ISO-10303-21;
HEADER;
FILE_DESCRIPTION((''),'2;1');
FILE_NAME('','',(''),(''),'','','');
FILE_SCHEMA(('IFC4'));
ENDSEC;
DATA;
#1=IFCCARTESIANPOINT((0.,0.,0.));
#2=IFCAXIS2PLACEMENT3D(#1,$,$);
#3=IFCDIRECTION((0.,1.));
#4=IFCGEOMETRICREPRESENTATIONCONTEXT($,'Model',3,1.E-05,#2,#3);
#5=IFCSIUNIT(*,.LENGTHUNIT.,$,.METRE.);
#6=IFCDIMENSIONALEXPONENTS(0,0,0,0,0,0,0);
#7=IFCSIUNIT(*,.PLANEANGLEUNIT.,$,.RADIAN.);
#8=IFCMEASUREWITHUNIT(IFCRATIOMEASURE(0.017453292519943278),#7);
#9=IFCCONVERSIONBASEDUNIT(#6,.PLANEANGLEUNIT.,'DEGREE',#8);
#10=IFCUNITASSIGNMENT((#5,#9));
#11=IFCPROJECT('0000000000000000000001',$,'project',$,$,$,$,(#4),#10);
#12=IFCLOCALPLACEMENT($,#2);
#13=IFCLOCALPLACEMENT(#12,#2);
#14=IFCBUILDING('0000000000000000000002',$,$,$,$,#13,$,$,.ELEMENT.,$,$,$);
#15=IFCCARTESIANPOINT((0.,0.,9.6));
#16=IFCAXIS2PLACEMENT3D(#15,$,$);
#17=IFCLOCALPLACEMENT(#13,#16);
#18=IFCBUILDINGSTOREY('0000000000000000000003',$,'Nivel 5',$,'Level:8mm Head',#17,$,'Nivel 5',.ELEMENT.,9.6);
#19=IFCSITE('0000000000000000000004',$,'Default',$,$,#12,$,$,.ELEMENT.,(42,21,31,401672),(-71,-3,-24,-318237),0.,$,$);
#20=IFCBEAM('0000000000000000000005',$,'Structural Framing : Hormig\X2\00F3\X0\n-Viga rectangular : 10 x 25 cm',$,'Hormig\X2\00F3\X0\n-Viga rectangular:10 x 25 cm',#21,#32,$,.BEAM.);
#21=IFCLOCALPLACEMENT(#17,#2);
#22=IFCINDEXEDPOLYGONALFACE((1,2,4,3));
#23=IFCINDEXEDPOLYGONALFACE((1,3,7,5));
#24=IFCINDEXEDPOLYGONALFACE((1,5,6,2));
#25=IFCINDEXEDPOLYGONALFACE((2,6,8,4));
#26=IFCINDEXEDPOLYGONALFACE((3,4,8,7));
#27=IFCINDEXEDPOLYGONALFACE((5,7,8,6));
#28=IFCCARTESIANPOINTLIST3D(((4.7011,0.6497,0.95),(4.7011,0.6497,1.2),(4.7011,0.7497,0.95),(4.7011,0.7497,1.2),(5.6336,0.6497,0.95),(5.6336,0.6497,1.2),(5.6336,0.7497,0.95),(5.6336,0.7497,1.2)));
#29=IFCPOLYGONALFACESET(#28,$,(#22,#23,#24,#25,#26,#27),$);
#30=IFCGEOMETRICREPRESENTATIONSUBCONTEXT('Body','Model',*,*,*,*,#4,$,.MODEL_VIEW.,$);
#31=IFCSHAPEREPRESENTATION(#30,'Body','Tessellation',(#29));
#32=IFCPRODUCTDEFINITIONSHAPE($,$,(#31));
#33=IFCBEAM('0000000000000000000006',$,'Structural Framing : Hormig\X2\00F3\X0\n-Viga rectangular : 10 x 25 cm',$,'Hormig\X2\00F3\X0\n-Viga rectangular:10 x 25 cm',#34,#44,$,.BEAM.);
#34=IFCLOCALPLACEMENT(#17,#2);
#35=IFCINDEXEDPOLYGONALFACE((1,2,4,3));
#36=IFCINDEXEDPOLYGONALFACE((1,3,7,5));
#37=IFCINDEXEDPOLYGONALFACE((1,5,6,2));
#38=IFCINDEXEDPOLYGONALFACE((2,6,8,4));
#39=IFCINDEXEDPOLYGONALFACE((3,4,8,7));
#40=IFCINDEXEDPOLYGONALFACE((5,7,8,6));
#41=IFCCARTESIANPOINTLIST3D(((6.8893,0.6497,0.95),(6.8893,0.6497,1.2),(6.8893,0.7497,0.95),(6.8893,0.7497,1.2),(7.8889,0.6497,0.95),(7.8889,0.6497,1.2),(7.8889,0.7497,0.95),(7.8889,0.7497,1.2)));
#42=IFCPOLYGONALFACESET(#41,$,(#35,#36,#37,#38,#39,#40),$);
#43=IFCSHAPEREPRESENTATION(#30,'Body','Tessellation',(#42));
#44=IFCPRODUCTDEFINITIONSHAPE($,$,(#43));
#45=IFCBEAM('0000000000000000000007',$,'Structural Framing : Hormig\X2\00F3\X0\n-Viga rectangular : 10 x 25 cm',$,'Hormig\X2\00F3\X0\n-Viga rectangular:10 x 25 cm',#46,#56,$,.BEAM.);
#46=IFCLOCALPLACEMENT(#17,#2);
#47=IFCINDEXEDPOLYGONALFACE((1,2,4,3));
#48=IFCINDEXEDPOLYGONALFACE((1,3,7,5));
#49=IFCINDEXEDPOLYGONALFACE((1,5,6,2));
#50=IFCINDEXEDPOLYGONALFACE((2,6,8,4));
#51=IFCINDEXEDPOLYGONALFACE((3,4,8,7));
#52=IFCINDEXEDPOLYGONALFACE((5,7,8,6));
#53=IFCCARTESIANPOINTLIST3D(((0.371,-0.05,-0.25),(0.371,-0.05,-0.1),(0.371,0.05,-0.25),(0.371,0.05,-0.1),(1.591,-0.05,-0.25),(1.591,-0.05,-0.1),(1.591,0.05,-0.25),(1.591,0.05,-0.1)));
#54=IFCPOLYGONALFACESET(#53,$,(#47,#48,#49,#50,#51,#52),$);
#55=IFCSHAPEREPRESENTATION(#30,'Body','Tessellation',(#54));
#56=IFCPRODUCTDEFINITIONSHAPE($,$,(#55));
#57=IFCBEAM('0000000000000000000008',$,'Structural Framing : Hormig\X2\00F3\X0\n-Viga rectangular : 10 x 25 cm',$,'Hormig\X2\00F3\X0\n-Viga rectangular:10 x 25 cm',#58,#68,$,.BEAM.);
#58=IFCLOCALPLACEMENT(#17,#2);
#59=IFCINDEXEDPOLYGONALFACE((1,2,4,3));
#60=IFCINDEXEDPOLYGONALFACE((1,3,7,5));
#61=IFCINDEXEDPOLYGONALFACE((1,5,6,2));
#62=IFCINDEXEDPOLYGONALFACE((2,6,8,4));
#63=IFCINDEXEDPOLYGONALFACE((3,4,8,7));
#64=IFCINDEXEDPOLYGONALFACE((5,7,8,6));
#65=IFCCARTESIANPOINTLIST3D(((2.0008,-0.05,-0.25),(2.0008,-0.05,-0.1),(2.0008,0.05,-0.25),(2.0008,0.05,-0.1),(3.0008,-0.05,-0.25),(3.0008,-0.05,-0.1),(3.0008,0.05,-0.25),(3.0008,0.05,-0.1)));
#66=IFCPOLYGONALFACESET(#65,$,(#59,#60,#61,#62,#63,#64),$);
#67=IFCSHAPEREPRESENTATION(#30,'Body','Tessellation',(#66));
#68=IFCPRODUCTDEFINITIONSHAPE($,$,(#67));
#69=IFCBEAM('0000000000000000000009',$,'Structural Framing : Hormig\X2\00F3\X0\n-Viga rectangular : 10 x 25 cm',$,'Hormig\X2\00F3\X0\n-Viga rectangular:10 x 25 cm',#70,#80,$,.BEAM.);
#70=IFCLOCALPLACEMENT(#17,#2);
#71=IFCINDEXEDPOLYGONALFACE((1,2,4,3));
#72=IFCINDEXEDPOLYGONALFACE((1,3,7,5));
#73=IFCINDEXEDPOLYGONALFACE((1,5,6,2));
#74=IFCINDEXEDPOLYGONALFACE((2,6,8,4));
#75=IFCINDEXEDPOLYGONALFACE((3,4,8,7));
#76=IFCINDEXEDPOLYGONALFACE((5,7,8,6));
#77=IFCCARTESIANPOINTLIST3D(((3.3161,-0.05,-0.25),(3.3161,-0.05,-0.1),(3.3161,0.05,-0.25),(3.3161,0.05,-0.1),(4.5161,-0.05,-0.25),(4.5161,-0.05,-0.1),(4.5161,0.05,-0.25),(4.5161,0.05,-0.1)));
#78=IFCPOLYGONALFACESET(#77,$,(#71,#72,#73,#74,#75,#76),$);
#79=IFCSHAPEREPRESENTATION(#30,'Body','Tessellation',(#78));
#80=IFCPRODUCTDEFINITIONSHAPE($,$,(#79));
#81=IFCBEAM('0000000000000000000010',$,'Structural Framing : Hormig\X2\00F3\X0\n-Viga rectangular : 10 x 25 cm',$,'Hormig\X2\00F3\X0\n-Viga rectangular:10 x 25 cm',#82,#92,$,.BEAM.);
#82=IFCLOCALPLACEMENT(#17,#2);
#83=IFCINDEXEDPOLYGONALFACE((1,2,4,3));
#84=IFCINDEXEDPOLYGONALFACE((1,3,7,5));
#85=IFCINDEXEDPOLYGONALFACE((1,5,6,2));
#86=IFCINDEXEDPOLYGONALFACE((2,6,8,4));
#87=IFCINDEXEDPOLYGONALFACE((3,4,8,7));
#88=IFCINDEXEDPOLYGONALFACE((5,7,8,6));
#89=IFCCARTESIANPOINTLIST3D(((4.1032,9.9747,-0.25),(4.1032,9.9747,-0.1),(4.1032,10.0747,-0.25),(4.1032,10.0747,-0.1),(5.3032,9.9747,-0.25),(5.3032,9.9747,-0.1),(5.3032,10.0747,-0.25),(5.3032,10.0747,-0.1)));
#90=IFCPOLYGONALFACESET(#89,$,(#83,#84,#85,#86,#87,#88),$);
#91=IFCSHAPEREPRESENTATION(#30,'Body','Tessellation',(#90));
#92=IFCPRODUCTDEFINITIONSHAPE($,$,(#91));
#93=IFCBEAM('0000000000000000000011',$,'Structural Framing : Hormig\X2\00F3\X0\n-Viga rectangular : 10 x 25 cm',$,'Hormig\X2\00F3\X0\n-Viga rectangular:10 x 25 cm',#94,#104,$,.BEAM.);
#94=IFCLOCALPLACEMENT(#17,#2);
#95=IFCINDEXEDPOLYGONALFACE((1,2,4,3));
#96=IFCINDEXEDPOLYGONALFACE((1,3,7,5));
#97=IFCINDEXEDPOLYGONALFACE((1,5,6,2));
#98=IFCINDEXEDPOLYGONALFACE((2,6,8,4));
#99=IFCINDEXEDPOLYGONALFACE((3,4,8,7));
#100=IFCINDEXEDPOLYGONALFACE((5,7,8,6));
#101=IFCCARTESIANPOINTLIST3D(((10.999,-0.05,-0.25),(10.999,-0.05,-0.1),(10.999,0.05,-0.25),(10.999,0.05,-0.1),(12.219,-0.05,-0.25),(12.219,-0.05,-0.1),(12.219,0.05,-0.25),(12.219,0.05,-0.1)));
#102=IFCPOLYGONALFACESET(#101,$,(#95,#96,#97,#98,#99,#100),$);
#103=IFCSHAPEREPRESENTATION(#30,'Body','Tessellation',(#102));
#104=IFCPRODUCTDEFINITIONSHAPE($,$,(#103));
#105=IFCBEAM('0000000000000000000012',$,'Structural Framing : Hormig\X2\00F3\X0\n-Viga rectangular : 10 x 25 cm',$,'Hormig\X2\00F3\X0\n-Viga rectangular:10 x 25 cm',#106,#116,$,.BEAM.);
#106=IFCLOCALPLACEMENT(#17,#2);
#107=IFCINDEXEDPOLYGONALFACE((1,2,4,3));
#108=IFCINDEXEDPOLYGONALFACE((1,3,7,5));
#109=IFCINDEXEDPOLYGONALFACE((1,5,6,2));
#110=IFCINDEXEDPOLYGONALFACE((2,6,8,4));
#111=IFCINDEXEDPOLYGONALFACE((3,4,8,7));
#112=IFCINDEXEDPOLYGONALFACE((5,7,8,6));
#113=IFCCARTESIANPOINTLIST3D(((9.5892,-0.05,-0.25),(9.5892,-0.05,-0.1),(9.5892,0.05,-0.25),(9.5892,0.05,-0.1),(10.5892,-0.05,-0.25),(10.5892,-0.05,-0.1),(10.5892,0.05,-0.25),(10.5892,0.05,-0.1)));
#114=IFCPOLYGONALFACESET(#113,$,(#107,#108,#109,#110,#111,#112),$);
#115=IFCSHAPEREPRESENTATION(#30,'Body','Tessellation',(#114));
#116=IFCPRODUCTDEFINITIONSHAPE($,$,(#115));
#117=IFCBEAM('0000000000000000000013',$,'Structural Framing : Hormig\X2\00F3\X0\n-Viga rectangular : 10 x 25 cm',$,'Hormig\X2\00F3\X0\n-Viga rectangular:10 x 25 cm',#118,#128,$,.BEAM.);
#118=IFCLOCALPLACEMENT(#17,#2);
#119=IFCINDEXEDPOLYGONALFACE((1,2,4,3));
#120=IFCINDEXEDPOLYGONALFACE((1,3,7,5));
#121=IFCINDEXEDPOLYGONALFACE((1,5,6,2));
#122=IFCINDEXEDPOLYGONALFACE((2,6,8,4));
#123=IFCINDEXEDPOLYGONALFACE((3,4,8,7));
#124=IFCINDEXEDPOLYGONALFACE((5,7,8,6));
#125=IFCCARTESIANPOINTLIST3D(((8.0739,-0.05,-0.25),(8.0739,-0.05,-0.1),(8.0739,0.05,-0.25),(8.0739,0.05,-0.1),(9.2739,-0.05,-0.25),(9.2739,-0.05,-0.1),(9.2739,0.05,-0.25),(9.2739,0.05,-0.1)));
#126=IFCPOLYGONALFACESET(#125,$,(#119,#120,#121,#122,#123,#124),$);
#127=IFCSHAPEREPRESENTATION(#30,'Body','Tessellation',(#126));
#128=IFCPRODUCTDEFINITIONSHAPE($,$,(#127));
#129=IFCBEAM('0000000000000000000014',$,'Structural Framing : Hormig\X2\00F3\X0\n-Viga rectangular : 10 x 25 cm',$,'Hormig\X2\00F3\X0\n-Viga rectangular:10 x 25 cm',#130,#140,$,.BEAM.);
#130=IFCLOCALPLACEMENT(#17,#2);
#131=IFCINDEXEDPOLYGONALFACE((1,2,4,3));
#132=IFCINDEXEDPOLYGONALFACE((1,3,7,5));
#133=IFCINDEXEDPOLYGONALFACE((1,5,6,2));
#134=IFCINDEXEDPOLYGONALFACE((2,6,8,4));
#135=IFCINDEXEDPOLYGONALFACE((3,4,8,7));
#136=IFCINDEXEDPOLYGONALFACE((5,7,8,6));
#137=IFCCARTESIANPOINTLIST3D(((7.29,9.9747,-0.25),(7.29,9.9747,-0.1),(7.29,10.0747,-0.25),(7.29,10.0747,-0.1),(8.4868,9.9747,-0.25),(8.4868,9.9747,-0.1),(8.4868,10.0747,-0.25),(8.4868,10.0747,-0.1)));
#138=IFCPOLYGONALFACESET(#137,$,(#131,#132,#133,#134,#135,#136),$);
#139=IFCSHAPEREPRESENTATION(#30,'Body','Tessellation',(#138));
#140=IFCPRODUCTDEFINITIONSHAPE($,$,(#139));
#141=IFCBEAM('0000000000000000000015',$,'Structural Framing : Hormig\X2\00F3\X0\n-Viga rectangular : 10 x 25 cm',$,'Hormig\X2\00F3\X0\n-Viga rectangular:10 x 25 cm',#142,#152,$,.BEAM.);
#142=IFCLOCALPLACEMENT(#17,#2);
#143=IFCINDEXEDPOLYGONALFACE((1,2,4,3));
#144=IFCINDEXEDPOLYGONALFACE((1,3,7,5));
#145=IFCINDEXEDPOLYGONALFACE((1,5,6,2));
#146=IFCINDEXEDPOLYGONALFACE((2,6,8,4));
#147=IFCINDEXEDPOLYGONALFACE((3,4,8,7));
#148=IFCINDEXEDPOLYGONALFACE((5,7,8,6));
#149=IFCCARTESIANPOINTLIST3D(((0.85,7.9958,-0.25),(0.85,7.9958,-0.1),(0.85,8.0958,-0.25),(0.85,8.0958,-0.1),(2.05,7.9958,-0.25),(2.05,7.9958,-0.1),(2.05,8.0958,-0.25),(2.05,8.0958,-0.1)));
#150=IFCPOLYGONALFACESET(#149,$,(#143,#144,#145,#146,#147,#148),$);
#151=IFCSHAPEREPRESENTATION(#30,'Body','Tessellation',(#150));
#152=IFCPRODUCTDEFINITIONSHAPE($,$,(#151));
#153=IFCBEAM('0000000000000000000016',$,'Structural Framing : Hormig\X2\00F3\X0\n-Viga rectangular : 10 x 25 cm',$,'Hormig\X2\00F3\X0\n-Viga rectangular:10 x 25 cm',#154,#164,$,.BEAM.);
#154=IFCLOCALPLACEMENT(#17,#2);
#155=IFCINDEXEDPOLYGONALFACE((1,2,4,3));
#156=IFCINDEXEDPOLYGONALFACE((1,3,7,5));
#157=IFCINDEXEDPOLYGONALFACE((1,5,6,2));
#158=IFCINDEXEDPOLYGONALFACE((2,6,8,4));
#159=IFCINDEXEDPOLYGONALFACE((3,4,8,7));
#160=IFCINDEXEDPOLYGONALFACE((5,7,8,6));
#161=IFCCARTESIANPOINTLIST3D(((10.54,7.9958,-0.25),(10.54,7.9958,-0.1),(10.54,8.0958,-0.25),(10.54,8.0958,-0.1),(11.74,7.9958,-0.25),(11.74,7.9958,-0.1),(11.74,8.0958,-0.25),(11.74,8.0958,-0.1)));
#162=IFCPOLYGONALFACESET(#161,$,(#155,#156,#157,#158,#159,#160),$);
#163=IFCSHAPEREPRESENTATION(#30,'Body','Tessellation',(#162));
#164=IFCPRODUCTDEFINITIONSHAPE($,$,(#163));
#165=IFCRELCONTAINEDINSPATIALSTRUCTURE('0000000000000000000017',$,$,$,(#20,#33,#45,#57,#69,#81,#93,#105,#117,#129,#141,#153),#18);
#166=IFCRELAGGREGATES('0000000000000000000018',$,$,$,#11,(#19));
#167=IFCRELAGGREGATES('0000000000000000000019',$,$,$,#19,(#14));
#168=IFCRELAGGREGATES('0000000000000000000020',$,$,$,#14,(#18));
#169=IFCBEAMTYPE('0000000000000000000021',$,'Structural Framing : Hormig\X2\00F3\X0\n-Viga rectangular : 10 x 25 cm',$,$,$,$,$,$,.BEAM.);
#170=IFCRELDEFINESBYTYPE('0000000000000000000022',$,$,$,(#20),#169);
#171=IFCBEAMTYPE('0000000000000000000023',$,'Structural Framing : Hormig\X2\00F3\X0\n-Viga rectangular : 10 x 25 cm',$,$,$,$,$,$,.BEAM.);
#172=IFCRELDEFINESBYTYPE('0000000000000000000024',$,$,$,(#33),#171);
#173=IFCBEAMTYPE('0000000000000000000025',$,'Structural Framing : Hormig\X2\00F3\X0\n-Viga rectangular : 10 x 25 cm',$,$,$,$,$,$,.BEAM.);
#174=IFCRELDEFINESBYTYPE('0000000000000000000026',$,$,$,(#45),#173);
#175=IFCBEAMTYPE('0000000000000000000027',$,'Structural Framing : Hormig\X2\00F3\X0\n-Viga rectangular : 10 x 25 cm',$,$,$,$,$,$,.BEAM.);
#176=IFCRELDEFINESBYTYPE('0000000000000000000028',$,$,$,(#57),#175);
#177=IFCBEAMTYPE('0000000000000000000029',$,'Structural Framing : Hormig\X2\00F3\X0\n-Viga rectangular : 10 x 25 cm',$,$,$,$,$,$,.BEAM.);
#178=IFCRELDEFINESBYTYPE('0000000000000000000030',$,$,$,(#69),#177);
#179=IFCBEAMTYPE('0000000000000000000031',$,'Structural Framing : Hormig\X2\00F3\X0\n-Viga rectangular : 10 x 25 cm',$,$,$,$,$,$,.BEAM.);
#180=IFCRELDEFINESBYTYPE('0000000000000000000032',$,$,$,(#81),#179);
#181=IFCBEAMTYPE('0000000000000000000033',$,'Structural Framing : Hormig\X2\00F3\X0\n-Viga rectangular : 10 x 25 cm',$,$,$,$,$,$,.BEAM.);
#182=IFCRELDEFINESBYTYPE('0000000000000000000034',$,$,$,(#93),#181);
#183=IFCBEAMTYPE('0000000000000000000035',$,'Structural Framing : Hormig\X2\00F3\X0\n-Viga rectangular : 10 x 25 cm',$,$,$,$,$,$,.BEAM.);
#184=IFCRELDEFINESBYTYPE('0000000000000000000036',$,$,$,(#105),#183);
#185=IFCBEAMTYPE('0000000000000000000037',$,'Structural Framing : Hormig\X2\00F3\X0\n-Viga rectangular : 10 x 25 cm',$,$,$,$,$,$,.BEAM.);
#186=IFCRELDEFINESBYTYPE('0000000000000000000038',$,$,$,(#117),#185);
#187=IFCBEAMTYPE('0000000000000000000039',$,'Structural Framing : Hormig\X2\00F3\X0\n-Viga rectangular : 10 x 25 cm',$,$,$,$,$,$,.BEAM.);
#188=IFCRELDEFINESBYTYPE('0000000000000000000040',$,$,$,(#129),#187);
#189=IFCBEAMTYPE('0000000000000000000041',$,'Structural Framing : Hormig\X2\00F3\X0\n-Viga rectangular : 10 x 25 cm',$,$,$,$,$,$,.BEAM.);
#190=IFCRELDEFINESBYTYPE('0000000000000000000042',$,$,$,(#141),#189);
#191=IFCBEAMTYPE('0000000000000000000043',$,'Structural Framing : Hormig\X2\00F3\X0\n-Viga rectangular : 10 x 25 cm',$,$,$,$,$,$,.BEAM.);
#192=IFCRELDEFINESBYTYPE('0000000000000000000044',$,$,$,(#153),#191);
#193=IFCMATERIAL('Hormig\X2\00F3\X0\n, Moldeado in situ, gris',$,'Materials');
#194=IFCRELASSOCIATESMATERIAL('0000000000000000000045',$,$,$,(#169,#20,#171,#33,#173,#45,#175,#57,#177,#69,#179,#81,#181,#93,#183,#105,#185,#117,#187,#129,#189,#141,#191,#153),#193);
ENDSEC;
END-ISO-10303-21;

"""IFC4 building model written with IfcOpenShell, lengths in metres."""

from ifc_helpers import new_model, entity, si_unit, converted_unit, direction, frame, origin, place, context, subcontext, project, spatial, indexed_curve, outline, extrude, source, transform, mapped, material, type_object, type_shapes, element, save


model = new_model("IFC4")

# Units and contexts
model_context = context("Model", 3, precision=1e-05, world=origin(), true_north=direction((0.0, 1.0)))
body_context = subcontext(model_context, "Body", "Model", "MODEL_VIEW")
ifc_project = project(units=[si_unit("LENGTHUNIT", "METRE"), converted_unit("PLANEANGLEUNIT", "DEGREE", entity("IfcRatioMeasure", 0.017453292519943278), si_unit("PLANEANGLEUNIT", "RADIAN"), dimensions=[0, 0, 0, 0, 0, 0, 0])], contexts=[model_context])

# Site, building, storey
site_placement = place(None, origin())
site = spatial("IfcSite", under=ifc_project, at=site_placement, Name="Default", CompositionType="ELEMENT", RefLatitude=(42, 21, 31, 401672), RefLongitude=(-71, -3, -24, -318237), RefElevation=0.0)
building_placement = place(site_placement, origin())
building = spatial("IfcBuilding", under=site, at=building_placement, CompositionType="ELEMENT")
storey_placement = place(building_placement, frame((0.0, 0.0, 9.6)))
storey = spatial("IfcBuildingStorey", under=building, at=storey_placement, Name="Nivel 5", ObjectType="Level:8mm Head", LongName="Nivel 5", CompositionType="ELEMENT", Elevation=9.6)

# Beams
ifc_material_1 = material(Name="Hormigón, Moldeado in situ, gris", Category="Materials")
beam_type_1 = type_object("IfcBeamType", Name="Structural Framing : Hormigón-Viga rectangular : 10 x 25 cm", PredefinedType="BEAM", material=ifc_material_1)
shared_shape_1 = source(origin(), body_context, "Body", "SweptSolid", [
    extrude(outline(indexed_curve([(-0.125, -0.05), (0.125, -0.05), (0.125, 0.05), (-0.125, 0.05), (-0.125, -0.05)], self_intersect=False)), frame((5.6336, 0.6997, 10.675), z_axis=(-1.0, 0.0, 0.0), x_axis=(0.0, 0.0, -1.0)), (0.0, 0.0, 1.0), 0.9325),
])
type_shapes(beam_type_1, [shared_shape_1])
beam_1_placement = place(storey_placement, frame((0.0, 0.0, -9.6)))
element("IfcBeam", 1, at=beam_1_placement, inside=storey, type_object=beam_type_1, material=ifc_material_1, Name="Structural Framing : Hormigón-Viga rectangular : 10 x 25 cm", ObjectType="Hormigón-Viga rectangular:10 x 25 cm", PredefinedType="BEAM", context=body_context, shape_type="MappedRepresentation", body=[
    mapped(shared_shape_1, transform((0.0, 0.0, 0.0), scale=1.0)),
])
beam_type_2 = type_object("IfcBeamType", Name="Structural Framing : Hormigón-Viga rectangular : 10 x 25 cm", PredefinedType="BEAM", material=ifc_material_1)
shared_shape_2 = source(origin(), body_context, "Body", "SweptSolid", [
    extrude(outline(indexed_curve([(-0.125, -0.05), (0.125, -0.05), (0.125, 0.05), (-0.125, 0.05), (-0.125, -0.05)], self_intersect=False)), frame((7.8889, 0.6997, 10.675), z_axis=(-1.0, 0.0, 0.0), x_axis=(0.0, 0.0, -1.0)), (0.0, 0.0, 1.0), 0.9996),
])
type_shapes(beam_type_2, [shared_shape_2])
beam_2_placement = place(storey_placement, frame((0.0, 0.0, -9.6)))
element("IfcBeam", 2, at=beam_2_placement, inside=storey, type_object=beam_type_2, material=ifc_material_1, Name="Structural Framing : Hormigón-Viga rectangular : 10 x 25 cm", ObjectType="Hormigón-Viga rectangular:10 x 25 cm", PredefinedType="BEAM", context=body_context, shape_type="MappedRepresentation", body=[
    mapped(shared_shape_2, transform((0.0, 0.0, 0.0), scale=1.0)),
])
beam_type_3 = type_object("IfcBeamType", Name="Structural Framing : Hormigón-Viga rectangular : 10 x 25 cm", PredefinedType="BEAM", material=ifc_material_1)
shared_shape_3 = source(origin(), body_context, "Body", "SweptSolid", [
    extrude(outline(indexed_curve([(-0.075, -0.05), (0.075, -0.05), (0.075, 0.05), (-0.075, 0.05), (-0.075, -0.05)], self_intersect=False)), frame((0.371, 0.0, 9.425), z_axis=(1.0, 0.0, 0.0), x_axis=(0.0, 0.0, -1.0)), (0.0, 0.0, 1.0), 1.22),
])
type_shapes(beam_type_3, [shared_shape_3])
beam_3_placement = place(storey_placement, frame((0.0, 0.0, -9.6)))
element("IfcBeam", 3, at=beam_3_placement, inside=storey, type_object=beam_type_3, material=ifc_material_1, Name="Structural Framing : Hormigón-Viga rectangular : 10 x 25 cm", ObjectType="Hormigón-Viga rectangular:10 x 25 cm", PredefinedType="BEAM", context=body_context, shape_type="MappedRepresentation", body=[
    mapped(shared_shape_3, transform((0.0, 0.0, 0.0), scale=1.0)),
])
beam_type_4 = type_object("IfcBeamType", Name="Structural Framing : Hormigón-Viga rectangular : 10 x 25 cm", PredefinedType="BEAM", material=ifc_material_1)
shared_shape_4 = source(origin(), body_context, "Body", "SweptSolid", [
    extrude(outline(indexed_curve([(-0.075, -0.05), (0.075, -0.05), (0.075, 0.05), (-0.075, 0.05), (-0.075, -0.05)], self_intersect=False)), frame((2.0008, 0.0, 9.425), z_axis=(1.0, 0.0, 0.0), x_axis=(0.0, 0.0, -1.0)), (0.0, 0.0, 1.0), 1.0),
])
type_shapes(beam_type_4, [shared_shape_4])
beam_4_placement = place(storey_placement, frame((0.0, 0.0, -9.6)))
element("IfcBeam", 4, at=beam_4_placement, inside=storey, type_object=beam_type_4, material=ifc_material_1, Name="Structural Framing : Hormigón-Viga rectangular : 10 x 25 cm", ObjectType="Hormigón-Viga rectangular:10 x 25 cm", PredefinedType="BEAM", context=body_context, shape_type="MappedRepresentation", body=[
    mapped(shared_shape_4, transform((0.0, 0.0, 0.0), scale=1.0)),
])
beam_type_5 = type_object("IfcBeamType", Name="Structural Framing : Hormigón-Viga rectangular : 10 x 25 cm", PredefinedType="BEAM", material=ifc_material_1)
shared_shape_5 = source(origin(), body_context, "Body", "SweptSolid", [
    extrude(outline(indexed_curve([(-0.075, -0.05), (0.075, -0.05), (0.075, 0.05), (-0.075, 0.05), (-0.075, -0.05)], self_intersect=False)), frame((3.3161, 0.0, 9.425), z_axis=(1.0, 0.0, 0.0), x_axis=(0.0, 0.0, -1.0)), (0.0, 0.0, 1.0), 1.2),
])
type_shapes(beam_type_5, [shared_shape_5])
beam_5_placement = place(storey_placement, frame((0.0, 0.0, -9.6)))
element("IfcBeam", 5, at=beam_5_placement, inside=storey, type_object=beam_type_5, material=ifc_material_1, Name="Structural Framing : Hormigón-Viga rectangular : 10 x 25 cm", ObjectType="Hormigón-Viga rectangular:10 x 25 cm", PredefinedType="BEAM", context=body_context, shape_type="MappedRepresentation", body=[
    mapped(shared_shape_5, transform((0.0, 0.0, 0.0), scale=1.0)),
])
beam_type_6 = type_object("IfcBeamType", Name="Structural Framing : Hormigón-Viga rectangular : 10 x 25 cm", PredefinedType="BEAM", material=ifc_material_1)
shared_shape_6 = source(origin(), body_context, "Body", "SweptSolid", [
    extrude(outline(indexed_curve([(-0.075, -0.05), (0.075, -0.05), (0.075, 0.05), (-0.075, 0.05), (-0.075, -0.05)], self_intersect=False)), frame((5.3032, 10.0247, 9.425), z_axis=(-1.0, 0.0, 0.0), x_axis=(0.0, 0.0, -1.0)), (0.0, 0.0, 1.0), 1.2),
])
type_shapes(beam_type_6, [shared_shape_6])
beam_6_placement = place(storey_placement, frame((0.0, 0.0, -9.6)))
element("IfcBeam", 6, at=beam_6_placement, inside=storey, type_object=beam_type_6, material=ifc_material_1, Name="Structural Framing : Hormigón-Viga rectangular : 10 x 25 cm", ObjectType="Hormigón-Viga rectangular:10 x 25 cm", PredefinedType="BEAM", context=body_context, shape_type="MappedRepresentation", body=[
    mapped(shared_shape_6, transform((0.0, 0.0, 0.0), scale=1.0)),
])
beam_type_7 = type_object("IfcBeamType", Name="Structural Framing : Hormigón-Viga rectangular : 10 x 25 cm", PredefinedType="BEAM", material=ifc_material_1)
shared_shape_7 = source(origin(), body_context, "Body", "SweptSolid", [
    extrude(outline(indexed_curve([(-0.075, -0.05), (0.075, -0.05), (0.075, 0.05), (-0.075, 0.05), (-0.075, -0.05)], self_intersect=False)), frame((12.219, 0.0, 9.425), z_axis=(-1.0, 0.0, 0.0), x_axis=(0.0, 0.0, -1.0)), (0.0, 0.0, 1.0), 1.22),
])
type_shapes(beam_type_7, [shared_shape_7])
beam_7_placement = place(storey_placement, frame((0.0, 0.0, -9.6)))
element("IfcBeam", 7, at=beam_7_placement, inside=storey, type_object=beam_type_7, material=ifc_material_1, Name="Structural Framing : Hormigón-Viga rectangular : 10 x 25 cm", ObjectType="Hormigón-Viga rectangular:10 x 25 cm", PredefinedType="BEAM", context=body_context, shape_type="MappedRepresentation", body=[
    mapped(shared_shape_7, transform((0.0, 0.0, 0.0), scale=1.0)),
])
beam_type_8 = type_object("IfcBeamType", Name="Structural Framing : Hormigón-Viga rectangular : 10 x 25 cm", PredefinedType="BEAM", material=ifc_material_1)
shared_shape_8 = source(origin(), body_context, "Body", "SweptSolid", [
    extrude(outline(indexed_curve([(-0.075, -0.05), (0.075, -0.05), (0.075, 0.05), (-0.075, 0.05), (-0.075, -0.05)], self_intersect=False)), frame((10.5892, 0.0, 9.425), z_axis=(-1.0, 0.0, 0.0), x_axis=(0.0, 0.0, -1.0)), (0.0, 0.0, 1.0), 1.0),
])
type_shapes(beam_type_8, [shared_shape_8])
beam_8_placement = place(storey_placement, frame((0.0, 0.0, -9.6)))
element("IfcBeam", 8, at=beam_8_placement, inside=storey, type_object=beam_type_8, material=ifc_material_1, Name="Structural Framing : Hormigón-Viga rectangular : 10 x 25 cm", ObjectType="Hormigón-Viga rectangular:10 x 25 cm", PredefinedType="BEAM", context=body_context, shape_type="MappedRepresentation", body=[
    mapped(shared_shape_8, transform((0.0, 0.0, 0.0), scale=1.0)),
])
beam_type_9 = type_object("IfcBeamType", Name="Structural Framing : Hormigón-Viga rectangular : 10 x 25 cm", PredefinedType="BEAM", material=ifc_material_1)
shared_shape_9 = source(origin(), body_context, "Body", "SweptSolid", [
    extrude(outline(indexed_curve([(-0.075, -0.05), (0.075, -0.05), (0.075, 0.05), (-0.075, 0.05), (-0.075, -0.05)], self_intersect=False)), frame((9.2739, 0.0, 9.425), z_axis=(-1.0, 0.0, 0.0), x_axis=(0.0, 0.0, -1.0)), (0.0, 0.0, 1.0), 1.2),
])
type_shapes(beam_type_9, [shared_shape_9])
beam_9_placement = place(storey_placement, frame((0.0, 0.0, -9.6)))
element("IfcBeam", 9, at=beam_9_placement, inside=storey, type_object=beam_type_9, material=ifc_material_1, Name="Structural Framing : Hormigón-Viga rectangular : 10 x 25 cm", ObjectType="Hormigón-Viga rectangular:10 x 25 cm", PredefinedType="BEAM", context=body_context, shape_type="MappedRepresentation", body=[
    mapped(shared_shape_9, transform((0.0, 0.0, 0.0), scale=1.0)),
])
beam_type_10 = type_object("IfcBeamType", Name="Structural Framing : Hormigón-Viga rectangular : 10 x 25 cm", PredefinedType="BEAM", material=ifc_material_1)
shared_shape_10 = source(origin(), body_context, "Body", "SweptSolid", [
    extrude(outline(indexed_curve([(-0.075, -0.05), (0.075, -0.05), (0.075, 0.05), (-0.075, 0.05), (-0.075, -0.05)], self_intersect=False)), frame((7.29, 10.0247, 9.425), z_axis=(1.0, 0.0, 0.0), x_axis=(0.0, 0.0, -1.0)), (0.0, 0.0, 1.0), 1.1968),
])
type_shapes(beam_type_10, [shared_shape_10])
beam_10_placement = place(storey_placement, frame((0.0, 0.0, -9.6)))
element("IfcBeam", 10, at=beam_10_placement, inside=storey, type_object=beam_type_10, material=ifc_material_1, Name="Structural Framing : Hormigón-Viga rectangular : 10 x 25 cm", ObjectType="Hormigón-Viga rectangular:10 x 25 cm", PredefinedType="BEAM", context=body_context, shape_type="MappedRepresentation", body=[
    mapped(shared_shape_10, transform((0.0, 0.0, 0.0), scale=1.0)),
])
beam_type_11 = type_object("IfcBeamType", Name="Structural Framing : Hormigón-Viga rectangular : 10 x 25 cm", PredefinedType="BEAM", material=ifc_material_1)
shared_shape_11 = source(origin(), body_context, "Body", "SweptSolid", [
    extrude(outline(indexed_curve([(-0.075, -0.05), (0.075, -0.05), (0.075, 0.05), (-0.075, 0.05), (-0.075, -0.05)], self_intersect=False)), frame((2.05, 8.0458, 9.425), z_axis=(-1.0, 0.0, 0.0), x_axis=(0.0, 0.0, -1.0)), (0.0, 0.0, 1.0), 1.2),
])
type_shapes(beam_type_11, [shared_shape_11])
beam_11_placement = place(storey_placement, frame((0.0, 0.0, -9.6)))
element("IfcBeam", 11, at=beam_11_placement, inside=storey, type_object=beam_type_11, material=ifc_material_1, Name="Structural Framing : Hormigón-Viga rectangular : 10 x 25 cm", ObjectType="Hormigón-Viga rectangular:10 x 25 cm", PredefinedType="BEAM", context=body_context, shape_type="MappedRepresentation", body=[
    mapped(shared_shape_11, transform((0.0, 0.0, 0.0), scale=1.0)),
])
beam_type_12 = type_object("IfcBeamType", Name="Structural Framing : Hormigón-Viga rectangular : 10 x 25 cm", PredefinedType="BEAM", material=ifc_material_1)
shared_shape_12 = source(origin(), body_context, "Body", "SweptSolid", [
    extrude(outline(indexed_curve([(-0.075, -0.05), (0.075, -0.05), (0.075, 0.05), (-0.075, 0.05), (-0.075, -0.05)], self_intersect=False)), frame((10.54, 8.0458, 9.425), z_axis=(1.0, 0.0, 0.0), x_axis=(0.0, 0.0, -1.0)), (0.0, 0.0, 1.0), 1.2),
])
type_shapes(beam_type_12, [shared_shape_12])
beam_12_placement = place(storey_placement, frame((0.0, 0.0, -9.6)))
element("IfcBeam", 12, at=beam_12_placement, inside=storey, type_object=beam_type_12, material=ifc_material_1, Name="Structural Framing : Hormigón-Viga rectangular : 10 x 25 cm", ObjectType="Hormigón-Viga rectangular:10 x 25 cm", PredefinedType="BEAM", context=body_context, shape_type="MappedRepresentation", body=[
    mapped(shared_shape_12, transform((0.0, 0.0, 0.0), scale=1.0)),
])

save(model, "model.ifc")
